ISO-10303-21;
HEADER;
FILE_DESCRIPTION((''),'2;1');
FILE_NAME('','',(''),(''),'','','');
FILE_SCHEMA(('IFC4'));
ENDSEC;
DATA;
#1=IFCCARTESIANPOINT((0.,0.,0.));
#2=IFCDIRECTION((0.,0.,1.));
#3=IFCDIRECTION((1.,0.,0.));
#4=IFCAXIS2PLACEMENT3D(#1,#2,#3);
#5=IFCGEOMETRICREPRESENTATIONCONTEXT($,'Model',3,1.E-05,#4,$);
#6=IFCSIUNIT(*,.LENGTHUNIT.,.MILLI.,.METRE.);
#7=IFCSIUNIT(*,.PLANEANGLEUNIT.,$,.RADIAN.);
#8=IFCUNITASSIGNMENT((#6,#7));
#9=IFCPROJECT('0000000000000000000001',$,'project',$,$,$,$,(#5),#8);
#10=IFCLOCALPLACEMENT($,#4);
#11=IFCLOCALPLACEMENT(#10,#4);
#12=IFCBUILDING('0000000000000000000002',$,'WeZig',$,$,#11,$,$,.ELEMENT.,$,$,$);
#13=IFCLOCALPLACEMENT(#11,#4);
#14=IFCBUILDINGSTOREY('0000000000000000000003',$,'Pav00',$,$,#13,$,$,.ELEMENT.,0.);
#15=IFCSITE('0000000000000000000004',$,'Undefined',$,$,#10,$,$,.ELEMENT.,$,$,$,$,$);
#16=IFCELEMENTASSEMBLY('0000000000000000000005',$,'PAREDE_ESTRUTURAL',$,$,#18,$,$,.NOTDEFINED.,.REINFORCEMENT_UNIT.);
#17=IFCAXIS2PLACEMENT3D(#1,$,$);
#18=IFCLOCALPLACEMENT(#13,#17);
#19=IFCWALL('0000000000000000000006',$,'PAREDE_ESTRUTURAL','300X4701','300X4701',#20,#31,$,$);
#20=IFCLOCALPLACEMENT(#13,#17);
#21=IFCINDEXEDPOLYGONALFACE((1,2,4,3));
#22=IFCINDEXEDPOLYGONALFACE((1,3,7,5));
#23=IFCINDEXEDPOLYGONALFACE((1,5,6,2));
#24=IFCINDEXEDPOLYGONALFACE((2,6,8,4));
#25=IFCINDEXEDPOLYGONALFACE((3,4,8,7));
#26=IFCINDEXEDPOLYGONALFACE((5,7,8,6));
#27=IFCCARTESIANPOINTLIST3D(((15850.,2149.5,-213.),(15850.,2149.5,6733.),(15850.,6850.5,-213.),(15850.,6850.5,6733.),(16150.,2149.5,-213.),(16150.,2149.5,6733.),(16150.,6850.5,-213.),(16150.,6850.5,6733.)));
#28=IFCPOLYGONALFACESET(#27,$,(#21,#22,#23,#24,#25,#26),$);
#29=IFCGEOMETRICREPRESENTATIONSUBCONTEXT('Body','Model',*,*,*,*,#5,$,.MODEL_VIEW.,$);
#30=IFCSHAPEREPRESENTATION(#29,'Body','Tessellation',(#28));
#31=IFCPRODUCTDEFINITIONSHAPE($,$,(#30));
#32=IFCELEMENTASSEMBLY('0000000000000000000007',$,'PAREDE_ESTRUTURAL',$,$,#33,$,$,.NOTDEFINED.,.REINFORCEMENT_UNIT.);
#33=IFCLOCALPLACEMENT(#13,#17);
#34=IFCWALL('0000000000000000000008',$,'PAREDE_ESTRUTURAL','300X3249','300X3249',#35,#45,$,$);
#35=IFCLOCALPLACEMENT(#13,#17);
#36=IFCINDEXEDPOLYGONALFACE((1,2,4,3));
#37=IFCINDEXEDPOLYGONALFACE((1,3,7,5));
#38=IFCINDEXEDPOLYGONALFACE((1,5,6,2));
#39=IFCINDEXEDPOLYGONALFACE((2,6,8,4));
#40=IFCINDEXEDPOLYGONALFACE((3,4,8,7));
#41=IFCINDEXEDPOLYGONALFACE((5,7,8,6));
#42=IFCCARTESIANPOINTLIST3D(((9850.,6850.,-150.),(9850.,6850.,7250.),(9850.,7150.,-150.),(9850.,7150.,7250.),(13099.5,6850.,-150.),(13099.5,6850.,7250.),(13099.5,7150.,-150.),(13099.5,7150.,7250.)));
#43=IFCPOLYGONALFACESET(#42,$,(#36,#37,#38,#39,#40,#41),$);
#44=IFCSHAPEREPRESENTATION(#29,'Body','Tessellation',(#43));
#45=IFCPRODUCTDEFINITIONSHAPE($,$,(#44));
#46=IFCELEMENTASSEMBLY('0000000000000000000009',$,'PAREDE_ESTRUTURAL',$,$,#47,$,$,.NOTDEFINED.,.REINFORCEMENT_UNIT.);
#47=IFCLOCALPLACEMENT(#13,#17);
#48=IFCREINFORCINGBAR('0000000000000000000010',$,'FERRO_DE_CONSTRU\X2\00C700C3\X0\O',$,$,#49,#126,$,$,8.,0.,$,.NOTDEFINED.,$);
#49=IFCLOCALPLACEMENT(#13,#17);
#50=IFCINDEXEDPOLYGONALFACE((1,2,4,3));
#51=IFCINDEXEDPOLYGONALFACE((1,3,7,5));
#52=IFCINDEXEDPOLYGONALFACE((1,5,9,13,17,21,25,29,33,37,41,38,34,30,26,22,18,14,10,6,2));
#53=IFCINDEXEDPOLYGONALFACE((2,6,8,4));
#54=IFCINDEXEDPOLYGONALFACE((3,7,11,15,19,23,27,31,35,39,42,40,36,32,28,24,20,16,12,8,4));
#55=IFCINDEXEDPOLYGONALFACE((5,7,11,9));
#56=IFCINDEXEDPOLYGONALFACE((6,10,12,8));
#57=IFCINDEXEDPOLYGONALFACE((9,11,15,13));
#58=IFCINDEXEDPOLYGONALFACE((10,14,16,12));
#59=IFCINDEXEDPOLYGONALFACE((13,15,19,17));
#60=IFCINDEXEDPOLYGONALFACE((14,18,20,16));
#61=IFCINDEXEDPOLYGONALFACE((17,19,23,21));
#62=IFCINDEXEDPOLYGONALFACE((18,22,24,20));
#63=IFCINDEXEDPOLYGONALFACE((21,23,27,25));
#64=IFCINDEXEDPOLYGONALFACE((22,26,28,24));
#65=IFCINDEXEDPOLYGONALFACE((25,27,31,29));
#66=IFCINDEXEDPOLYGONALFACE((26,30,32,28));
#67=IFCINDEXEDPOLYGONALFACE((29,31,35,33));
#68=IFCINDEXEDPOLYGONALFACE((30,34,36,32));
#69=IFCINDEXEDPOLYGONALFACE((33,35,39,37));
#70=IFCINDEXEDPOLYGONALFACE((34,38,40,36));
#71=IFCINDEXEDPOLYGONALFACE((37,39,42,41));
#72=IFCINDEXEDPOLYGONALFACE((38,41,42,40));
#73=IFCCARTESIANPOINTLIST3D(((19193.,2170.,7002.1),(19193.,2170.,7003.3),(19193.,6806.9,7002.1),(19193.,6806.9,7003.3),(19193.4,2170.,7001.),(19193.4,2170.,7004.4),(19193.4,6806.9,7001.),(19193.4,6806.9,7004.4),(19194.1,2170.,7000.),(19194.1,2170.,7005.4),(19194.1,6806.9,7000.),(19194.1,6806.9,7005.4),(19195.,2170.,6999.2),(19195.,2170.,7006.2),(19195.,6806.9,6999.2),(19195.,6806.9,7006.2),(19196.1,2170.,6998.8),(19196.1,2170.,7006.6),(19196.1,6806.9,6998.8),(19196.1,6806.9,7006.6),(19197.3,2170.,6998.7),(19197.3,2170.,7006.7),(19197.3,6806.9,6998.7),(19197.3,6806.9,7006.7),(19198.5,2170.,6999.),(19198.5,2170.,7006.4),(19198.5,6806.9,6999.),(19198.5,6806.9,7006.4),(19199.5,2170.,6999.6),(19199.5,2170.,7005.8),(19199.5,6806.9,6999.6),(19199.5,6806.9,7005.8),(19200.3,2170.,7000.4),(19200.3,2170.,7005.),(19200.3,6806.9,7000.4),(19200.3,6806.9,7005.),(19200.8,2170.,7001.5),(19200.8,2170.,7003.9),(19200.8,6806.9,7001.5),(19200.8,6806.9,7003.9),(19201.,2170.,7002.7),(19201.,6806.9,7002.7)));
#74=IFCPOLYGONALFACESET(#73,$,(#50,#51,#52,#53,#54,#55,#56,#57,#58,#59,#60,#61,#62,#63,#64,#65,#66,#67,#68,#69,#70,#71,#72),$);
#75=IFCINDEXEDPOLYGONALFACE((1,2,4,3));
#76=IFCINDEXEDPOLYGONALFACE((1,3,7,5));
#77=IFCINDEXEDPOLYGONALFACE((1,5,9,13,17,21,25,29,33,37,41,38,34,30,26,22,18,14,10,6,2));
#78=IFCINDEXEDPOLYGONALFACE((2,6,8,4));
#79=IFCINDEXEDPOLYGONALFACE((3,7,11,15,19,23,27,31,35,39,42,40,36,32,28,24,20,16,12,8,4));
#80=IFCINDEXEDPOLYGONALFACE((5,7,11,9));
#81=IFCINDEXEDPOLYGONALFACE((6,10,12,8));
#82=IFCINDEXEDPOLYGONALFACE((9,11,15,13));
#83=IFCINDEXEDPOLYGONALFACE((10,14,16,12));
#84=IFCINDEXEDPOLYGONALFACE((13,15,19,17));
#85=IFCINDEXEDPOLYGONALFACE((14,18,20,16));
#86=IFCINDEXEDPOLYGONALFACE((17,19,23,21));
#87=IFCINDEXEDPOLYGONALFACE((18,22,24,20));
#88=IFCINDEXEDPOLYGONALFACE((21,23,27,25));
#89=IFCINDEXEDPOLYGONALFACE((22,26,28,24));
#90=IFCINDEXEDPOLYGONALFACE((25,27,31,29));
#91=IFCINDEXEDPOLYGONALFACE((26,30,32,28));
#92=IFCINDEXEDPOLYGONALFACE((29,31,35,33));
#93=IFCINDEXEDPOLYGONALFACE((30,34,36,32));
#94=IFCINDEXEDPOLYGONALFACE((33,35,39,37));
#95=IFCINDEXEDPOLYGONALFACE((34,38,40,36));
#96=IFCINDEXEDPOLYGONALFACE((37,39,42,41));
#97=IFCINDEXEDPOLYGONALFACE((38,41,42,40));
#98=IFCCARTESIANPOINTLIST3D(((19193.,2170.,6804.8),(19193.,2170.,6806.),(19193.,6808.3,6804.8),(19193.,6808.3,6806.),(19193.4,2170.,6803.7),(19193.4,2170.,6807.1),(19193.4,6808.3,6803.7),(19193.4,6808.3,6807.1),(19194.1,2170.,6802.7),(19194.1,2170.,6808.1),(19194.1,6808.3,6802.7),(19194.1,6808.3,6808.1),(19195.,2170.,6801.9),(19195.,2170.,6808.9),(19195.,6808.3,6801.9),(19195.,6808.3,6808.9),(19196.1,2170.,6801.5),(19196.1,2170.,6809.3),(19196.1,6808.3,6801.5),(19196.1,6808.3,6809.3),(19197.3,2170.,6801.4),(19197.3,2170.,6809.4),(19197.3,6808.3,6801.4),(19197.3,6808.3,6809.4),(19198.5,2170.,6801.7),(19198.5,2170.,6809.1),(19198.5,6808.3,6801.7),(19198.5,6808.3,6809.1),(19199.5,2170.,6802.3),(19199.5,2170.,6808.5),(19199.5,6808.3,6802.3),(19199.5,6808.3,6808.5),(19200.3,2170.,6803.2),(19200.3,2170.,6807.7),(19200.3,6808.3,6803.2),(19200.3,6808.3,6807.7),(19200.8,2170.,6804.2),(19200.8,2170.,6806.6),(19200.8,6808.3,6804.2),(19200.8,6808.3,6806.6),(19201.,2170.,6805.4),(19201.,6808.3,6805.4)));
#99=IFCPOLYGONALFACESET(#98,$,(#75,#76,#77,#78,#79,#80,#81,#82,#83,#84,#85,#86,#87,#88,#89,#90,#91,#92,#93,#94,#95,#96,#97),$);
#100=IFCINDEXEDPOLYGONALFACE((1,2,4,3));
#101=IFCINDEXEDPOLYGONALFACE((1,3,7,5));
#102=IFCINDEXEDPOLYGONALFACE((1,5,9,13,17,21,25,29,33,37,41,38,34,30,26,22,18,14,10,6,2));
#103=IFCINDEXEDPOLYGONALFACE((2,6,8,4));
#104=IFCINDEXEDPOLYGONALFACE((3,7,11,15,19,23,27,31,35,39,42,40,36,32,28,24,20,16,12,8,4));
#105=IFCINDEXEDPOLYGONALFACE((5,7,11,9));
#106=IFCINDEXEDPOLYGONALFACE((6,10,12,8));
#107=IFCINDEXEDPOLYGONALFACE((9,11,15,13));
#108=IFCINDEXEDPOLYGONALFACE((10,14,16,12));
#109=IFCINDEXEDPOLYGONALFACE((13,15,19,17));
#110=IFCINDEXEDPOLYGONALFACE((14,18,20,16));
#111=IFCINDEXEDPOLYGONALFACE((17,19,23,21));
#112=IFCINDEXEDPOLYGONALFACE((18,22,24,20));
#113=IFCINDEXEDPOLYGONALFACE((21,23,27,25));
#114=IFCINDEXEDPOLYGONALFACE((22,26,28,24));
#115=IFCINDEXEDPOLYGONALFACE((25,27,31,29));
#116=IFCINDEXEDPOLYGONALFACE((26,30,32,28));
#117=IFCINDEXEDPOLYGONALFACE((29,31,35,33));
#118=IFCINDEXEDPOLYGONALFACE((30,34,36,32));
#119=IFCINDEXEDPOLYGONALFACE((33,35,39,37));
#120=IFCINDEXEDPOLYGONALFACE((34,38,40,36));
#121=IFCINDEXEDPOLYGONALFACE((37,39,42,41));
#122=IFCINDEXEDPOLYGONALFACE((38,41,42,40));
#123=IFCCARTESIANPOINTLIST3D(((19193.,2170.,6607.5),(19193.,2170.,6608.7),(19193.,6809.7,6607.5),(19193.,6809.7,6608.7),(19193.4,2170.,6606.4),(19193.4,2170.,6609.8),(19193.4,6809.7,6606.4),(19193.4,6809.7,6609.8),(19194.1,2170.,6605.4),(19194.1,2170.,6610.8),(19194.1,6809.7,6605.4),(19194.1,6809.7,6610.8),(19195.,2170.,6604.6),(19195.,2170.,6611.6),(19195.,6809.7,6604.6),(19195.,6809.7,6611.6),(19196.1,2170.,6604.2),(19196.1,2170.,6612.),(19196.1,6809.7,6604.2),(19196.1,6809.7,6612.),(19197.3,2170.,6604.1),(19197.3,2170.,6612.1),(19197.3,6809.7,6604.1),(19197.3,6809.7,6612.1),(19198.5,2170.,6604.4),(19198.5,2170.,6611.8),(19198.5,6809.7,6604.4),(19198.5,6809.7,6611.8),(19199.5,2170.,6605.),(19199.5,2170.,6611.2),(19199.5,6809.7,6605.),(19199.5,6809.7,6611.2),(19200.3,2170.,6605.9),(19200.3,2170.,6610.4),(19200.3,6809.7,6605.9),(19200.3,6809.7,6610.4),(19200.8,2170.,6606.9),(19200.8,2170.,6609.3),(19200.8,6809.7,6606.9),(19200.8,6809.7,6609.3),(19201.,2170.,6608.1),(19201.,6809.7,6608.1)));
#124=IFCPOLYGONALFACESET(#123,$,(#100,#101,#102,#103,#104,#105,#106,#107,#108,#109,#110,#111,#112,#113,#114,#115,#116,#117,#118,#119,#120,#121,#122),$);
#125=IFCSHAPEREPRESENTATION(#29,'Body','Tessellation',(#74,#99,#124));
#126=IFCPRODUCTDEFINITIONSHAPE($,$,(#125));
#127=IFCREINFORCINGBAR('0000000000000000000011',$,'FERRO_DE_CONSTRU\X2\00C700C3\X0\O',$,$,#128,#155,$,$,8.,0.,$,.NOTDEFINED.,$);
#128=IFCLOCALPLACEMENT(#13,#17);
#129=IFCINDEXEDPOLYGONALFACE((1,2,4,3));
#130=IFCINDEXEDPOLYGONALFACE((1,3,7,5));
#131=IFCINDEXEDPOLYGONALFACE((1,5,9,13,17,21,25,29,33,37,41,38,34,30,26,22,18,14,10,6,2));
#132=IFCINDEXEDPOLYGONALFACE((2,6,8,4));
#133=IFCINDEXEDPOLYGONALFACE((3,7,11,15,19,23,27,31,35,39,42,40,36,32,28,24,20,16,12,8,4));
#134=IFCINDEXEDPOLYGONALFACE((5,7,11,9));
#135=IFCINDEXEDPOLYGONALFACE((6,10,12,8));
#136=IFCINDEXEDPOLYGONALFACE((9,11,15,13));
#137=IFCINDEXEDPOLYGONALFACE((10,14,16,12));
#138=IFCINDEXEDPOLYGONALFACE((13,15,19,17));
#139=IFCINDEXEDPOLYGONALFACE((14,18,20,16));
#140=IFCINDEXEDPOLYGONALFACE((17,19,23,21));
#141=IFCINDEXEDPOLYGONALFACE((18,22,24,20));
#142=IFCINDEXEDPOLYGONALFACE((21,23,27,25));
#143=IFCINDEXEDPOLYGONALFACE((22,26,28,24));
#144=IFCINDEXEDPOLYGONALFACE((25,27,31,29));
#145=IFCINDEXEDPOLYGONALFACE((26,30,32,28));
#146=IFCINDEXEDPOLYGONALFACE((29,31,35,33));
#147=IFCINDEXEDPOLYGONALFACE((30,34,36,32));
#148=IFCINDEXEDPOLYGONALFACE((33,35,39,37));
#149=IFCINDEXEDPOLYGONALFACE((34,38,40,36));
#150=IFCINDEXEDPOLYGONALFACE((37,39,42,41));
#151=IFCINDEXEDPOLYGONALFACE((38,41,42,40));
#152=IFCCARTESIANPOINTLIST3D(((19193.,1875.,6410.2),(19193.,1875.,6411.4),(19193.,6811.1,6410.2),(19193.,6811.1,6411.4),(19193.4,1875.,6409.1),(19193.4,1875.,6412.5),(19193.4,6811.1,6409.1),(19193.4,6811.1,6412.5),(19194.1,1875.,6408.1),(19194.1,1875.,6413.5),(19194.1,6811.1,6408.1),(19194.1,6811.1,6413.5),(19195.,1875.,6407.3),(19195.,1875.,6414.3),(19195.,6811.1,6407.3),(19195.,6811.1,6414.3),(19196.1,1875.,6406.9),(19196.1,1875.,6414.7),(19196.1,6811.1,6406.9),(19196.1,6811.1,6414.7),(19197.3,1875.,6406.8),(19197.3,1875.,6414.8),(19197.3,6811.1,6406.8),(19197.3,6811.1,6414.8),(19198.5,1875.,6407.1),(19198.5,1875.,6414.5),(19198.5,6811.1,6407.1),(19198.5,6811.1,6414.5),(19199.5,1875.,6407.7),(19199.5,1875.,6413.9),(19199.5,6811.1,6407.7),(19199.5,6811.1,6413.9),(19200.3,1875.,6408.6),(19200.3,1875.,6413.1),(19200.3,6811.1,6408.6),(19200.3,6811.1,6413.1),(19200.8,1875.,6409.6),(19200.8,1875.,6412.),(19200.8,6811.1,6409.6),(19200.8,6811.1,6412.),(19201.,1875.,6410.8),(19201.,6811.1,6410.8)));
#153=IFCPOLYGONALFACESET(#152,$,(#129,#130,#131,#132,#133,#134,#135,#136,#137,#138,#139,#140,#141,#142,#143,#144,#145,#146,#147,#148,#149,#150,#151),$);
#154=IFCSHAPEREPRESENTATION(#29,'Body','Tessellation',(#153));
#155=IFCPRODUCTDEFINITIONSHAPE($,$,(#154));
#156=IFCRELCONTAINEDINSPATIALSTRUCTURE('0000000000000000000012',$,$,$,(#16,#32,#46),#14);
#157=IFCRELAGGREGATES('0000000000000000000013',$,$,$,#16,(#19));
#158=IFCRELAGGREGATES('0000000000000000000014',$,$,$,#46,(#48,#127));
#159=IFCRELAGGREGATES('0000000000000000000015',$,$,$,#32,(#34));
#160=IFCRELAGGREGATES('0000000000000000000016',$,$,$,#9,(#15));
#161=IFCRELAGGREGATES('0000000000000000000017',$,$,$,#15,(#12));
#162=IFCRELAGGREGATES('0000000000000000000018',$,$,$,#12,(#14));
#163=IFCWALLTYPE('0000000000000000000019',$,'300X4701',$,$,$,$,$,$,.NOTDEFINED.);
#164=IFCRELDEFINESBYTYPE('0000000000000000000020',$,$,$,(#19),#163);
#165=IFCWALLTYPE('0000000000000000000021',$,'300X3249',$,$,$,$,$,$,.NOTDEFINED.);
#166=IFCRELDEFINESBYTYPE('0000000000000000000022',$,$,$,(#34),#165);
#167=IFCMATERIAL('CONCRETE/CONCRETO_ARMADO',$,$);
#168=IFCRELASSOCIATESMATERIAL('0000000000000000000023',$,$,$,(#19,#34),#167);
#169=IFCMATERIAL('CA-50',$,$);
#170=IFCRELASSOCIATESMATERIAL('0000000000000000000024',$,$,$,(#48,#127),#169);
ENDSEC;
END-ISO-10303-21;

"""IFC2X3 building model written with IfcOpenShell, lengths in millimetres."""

from ifc_helpers import new_model, entity, si_unit, frame, frame_2d, origin_with_axes, place, context, subcontext, project, spatial, rectangle, extrude, source, transform, mapped, material, type_object, element, aggregate, save


model = new_model("IFC2X3")

# Units and contexts
model_context = context("Model", 3, precision=1e-05, world=origin_with_axes())
body_context = subcontext(model_context, "Body", "Model", "MODEL_VIEW")
ifc_project = project(units=[si_unit("LENGTHUNIT", "METRE", prefix="MILLI"), si_unit("PLANEANGLEUNIT", "RADIAN")], contexts=[model_context])

# Site, building, storey
site_placement = place(None, origin_with_axes())
site = spatial("IfcSite", under=ifc_project, at=site_placement, Name="Undefined", CompositionType="ELEMENT")
building_placement = place(site_placement, origin_with_axes())
building = spatial("IfcBuilding", under=site, at=building_placement, Name="WeZig", CompositionType="ELEMENT")
storey_placement = place(building_placement, origin_with_axes())
storey = spatial("IfcBuildingStorey", under=building, at=storey_placement, Name="Pav00", CompositionType="ELEMENT", Elevation=0.0)

# Element assemblies, walls
assembly_1_placement = place(storey_placement, origin_with_axes())
assembly_1 = element("IfcElementAssembly", 1, at=assembly_1_placement, inside=storey, Name="PAREDE_ESTRUTURAL", AssemblyPlace="NOTDEFINED", PredefinedType="REINFORCEMENT_UNIT")
ifc_material_1 = material(Name="CONCRETE/CONCRETO_ARMADO")
wall_type_1 = type_object("IfcWallType", Name="300X4701", PredefinedType="NOTDEFINED")
wall_1_placement = place(assembly_1_placement, frame((16000.0, 6850.5, 909.5), z_axis=(0.0, 0.0, 1.0), x_axis=(0.0, -1.0, 0.0)))
wall_1 = element("IfcWall", 2, at=wall_1_placement, type_object=wall_type_1, material=ifc_material_1, Name="PAREDE_ESTRUTURAL", Description="300X4701", ObjectType="300X4701", context=body_context, shape_type="SweptSolid", body=[
    extrude(rectangle(XDim=4701.0, YDim=300.0, at=frame_2d((0.0, 2350.5), x_axis=(0.0, -1.0))), frame((0.0, 0.0, -1122.5), z_axis=(0.0, 0.0, 1.0), x_axis=(0.0, -1.0, 0.0)), (0.0, 0.0, 1.0), 6946.0),
])
assembly_2_placement = place(storey_placement, origin_with_axes())
assembly_2 = element("IfcElementAssembly", 3, at=assembly_2_placement, inside=storey, Name="PAREDE_ESTRUTURAL", AssemblyPlace="NOTDEFINED", PredefinedType="REINFORCEMENT_UNIT")
wall_type_2 = type_object("IfcWallType", Name="300X3249", PredefinedType="NOTDEFINED")
wall_2_placement = place(assembly_2_placement, frame((9850.0, 7000.0, 1925.2), z_axis=(0.0, 0.0, 1.0), x_axis=(1.0, 0.0, 0.0)))
wall_2 = element("IfcWall", 4, at=wall_2_placement, type_object=wall_type_2, material=ifc_material_1, Name="PAREDE_ESTRUTURAL", Description="300X3249", ObjectType="300X3249", context=body_context, shape_type="SweptSolid", body=[
    extrude(rectangle(XDim=3249.5, YDim=300.0, at=frame_2d((0.0, 1624.7), x_axis=(0.0, -1.0))), frame((0.0, 0.0, -2075.2), z_axis=(0.0, 0.0, 1.0), x_axis=(0.0, -1.0, 0.0)), (0.0, 0.0, 1.0), 7400.0),
])

# Shared definitions
ifc_material_2 = material(Name="CA-50")
aggregate(assembly_1, [wall_1])

# Element assembly, reinforcing bars
assembly_3_placement = place(storey_placement, origin_with_axes())
assembly_3 = element("IfcElementAssembly", 5, at=assembly_3_placement, inside=storey, Name="PAREDE_ESTRUTURAL", AssemblyPlace="NOTDEFINED", PredefinedType="REINFORCEMENT_UNIT")
shared_shape_1 = source(origin_with_axes(), body_context, "Body", "AdvancedSweptSolid", [
    entity("IfcSweptDiskSolid", entity("IfcTrimmedCurve", entity("IfcLine", entity("IfcCartesianPoint", [0.0, 0.0, 0.0]), entity("IfcVector", entity("IfcDirection", [1.0, 0.0, 0.0]), 1.0)), [entity("IfcParameterValue", 0.0)], [entity("IfcParameterValue", 4636.840933)], True, "PARAMETER"), 4.0, None, 0.0, 4636.8),
])
shared_shape_2 = source(origin_with_axes(), body_context, "Body", "AdvancedSweptSolid", [
    entity("IfcSweptDiskSolid", entity("IfcTrimmedCurve", entity("IfcLine", entity("IfcCartesianPoint", [0.0, 0.0, 0.0]), entity("IfcVector", entity("IfcDirection", [1.0, 0.0, 0.0]), 1.0)), [entity("IfcParameterValue", 0.0)], [entity("IfcParameterValue", 4638.25458)], True, "PARAMETER"), 4.0, None, 0.0, 4638.3),
])
shared_shape_3 = source(origin_with_axes(), body_context, "Body", "AdvancedSweptSolid", [
    entity("IfcSweptDiskSolid", entity("IfcTrimmedCurve", entity("IfcLine", entity("IfcCartesianPoint", [0.0, 0.0, 0.0]), entity("IfcVector", entity("IfcDirection", [1.0, 0.0, 0.0]), 1.0)), [entity("IfcParameterValue", 0.0)], [entity("IfcParameterValue", 4639.668227)], True, "PARAMETER"), 4.0, None, 0.0, 4639.7),
])
reinforcing_bar_1_placement = place(assembly_3_placement, frame((19197.0, 6806.9, 7002.7), z_axis=(1.0, 0.0, 0.0), x_axis=(0.0, -1.0, 0.0)))
reinforcing_bar_1 = element("IfcReinforcingBar", 6, at=reinforcing_bar_1_placement, material=ifc_material_2, Name="FERRO_DE_CONSTRUÇÃO", BarRole="NOTDEFINED", CrossSectionArea=0.0, NominalDiameter=8.0, context=body_context, shape_type="MappedRepresentation", body=[
    mapped(shared_shape_1, transform((0.0, 0.0, 0.0))),
    mapped(shared_shape_2, transform((-1.4, 197.3, 0.0))),
    mapped(shared_shape_3, transform((-2.8, 394.6, 0.0))),
])
shared_shape_4 = source(origin_with_axes(), body_context, "Body", "AdvancedSweptSolid", [
    entity("IfcSweptDiskSolid", entity("IfcTrimmedCurve", entity("IfcLine", entity("IfcCartesianPoint", [0.0, 0.0, 0.0]), entity("IfcVector", entity("IfcDirection", [1.0, 0.0, 0.0]), 1.0)), [entity("IfcParameterValue", 0.0)], [entity("IfcParameterValue", 4936.094132)], True, "PARAMETER"), 4.0, None, 0.0, 4936.1),
])
reinforcing_bar_2_placement = place(assembly_3_placement, frame((19197.0, 6811.1, 6410.8), z_axis=(1.0, 0.0, 0.0), x_axis=(0.0, -1.0, 0.0)))
reinforcing_bar_2 = element("IfcReinforcingBar", 7, at=reinforcing_bar_2_placement, material=ifc_material_2, Name="FERRO_DE_CONSTRUÇÃO", BarRole="NOTDEFINED", CrossSectionArea=0.0, NominalDiameter=8.0, context=body_context, shape_type="MappedRepresentation", body=[
    mapped(shared_shape_4, transform((0.0, 0.0, 0.0))),
])
aggregate(assembly_3, [reinforcing_bar_1, reinforcing_bar_2])

aggregate(assembly_2, [wall_2])

save(model, "model.ifc")
